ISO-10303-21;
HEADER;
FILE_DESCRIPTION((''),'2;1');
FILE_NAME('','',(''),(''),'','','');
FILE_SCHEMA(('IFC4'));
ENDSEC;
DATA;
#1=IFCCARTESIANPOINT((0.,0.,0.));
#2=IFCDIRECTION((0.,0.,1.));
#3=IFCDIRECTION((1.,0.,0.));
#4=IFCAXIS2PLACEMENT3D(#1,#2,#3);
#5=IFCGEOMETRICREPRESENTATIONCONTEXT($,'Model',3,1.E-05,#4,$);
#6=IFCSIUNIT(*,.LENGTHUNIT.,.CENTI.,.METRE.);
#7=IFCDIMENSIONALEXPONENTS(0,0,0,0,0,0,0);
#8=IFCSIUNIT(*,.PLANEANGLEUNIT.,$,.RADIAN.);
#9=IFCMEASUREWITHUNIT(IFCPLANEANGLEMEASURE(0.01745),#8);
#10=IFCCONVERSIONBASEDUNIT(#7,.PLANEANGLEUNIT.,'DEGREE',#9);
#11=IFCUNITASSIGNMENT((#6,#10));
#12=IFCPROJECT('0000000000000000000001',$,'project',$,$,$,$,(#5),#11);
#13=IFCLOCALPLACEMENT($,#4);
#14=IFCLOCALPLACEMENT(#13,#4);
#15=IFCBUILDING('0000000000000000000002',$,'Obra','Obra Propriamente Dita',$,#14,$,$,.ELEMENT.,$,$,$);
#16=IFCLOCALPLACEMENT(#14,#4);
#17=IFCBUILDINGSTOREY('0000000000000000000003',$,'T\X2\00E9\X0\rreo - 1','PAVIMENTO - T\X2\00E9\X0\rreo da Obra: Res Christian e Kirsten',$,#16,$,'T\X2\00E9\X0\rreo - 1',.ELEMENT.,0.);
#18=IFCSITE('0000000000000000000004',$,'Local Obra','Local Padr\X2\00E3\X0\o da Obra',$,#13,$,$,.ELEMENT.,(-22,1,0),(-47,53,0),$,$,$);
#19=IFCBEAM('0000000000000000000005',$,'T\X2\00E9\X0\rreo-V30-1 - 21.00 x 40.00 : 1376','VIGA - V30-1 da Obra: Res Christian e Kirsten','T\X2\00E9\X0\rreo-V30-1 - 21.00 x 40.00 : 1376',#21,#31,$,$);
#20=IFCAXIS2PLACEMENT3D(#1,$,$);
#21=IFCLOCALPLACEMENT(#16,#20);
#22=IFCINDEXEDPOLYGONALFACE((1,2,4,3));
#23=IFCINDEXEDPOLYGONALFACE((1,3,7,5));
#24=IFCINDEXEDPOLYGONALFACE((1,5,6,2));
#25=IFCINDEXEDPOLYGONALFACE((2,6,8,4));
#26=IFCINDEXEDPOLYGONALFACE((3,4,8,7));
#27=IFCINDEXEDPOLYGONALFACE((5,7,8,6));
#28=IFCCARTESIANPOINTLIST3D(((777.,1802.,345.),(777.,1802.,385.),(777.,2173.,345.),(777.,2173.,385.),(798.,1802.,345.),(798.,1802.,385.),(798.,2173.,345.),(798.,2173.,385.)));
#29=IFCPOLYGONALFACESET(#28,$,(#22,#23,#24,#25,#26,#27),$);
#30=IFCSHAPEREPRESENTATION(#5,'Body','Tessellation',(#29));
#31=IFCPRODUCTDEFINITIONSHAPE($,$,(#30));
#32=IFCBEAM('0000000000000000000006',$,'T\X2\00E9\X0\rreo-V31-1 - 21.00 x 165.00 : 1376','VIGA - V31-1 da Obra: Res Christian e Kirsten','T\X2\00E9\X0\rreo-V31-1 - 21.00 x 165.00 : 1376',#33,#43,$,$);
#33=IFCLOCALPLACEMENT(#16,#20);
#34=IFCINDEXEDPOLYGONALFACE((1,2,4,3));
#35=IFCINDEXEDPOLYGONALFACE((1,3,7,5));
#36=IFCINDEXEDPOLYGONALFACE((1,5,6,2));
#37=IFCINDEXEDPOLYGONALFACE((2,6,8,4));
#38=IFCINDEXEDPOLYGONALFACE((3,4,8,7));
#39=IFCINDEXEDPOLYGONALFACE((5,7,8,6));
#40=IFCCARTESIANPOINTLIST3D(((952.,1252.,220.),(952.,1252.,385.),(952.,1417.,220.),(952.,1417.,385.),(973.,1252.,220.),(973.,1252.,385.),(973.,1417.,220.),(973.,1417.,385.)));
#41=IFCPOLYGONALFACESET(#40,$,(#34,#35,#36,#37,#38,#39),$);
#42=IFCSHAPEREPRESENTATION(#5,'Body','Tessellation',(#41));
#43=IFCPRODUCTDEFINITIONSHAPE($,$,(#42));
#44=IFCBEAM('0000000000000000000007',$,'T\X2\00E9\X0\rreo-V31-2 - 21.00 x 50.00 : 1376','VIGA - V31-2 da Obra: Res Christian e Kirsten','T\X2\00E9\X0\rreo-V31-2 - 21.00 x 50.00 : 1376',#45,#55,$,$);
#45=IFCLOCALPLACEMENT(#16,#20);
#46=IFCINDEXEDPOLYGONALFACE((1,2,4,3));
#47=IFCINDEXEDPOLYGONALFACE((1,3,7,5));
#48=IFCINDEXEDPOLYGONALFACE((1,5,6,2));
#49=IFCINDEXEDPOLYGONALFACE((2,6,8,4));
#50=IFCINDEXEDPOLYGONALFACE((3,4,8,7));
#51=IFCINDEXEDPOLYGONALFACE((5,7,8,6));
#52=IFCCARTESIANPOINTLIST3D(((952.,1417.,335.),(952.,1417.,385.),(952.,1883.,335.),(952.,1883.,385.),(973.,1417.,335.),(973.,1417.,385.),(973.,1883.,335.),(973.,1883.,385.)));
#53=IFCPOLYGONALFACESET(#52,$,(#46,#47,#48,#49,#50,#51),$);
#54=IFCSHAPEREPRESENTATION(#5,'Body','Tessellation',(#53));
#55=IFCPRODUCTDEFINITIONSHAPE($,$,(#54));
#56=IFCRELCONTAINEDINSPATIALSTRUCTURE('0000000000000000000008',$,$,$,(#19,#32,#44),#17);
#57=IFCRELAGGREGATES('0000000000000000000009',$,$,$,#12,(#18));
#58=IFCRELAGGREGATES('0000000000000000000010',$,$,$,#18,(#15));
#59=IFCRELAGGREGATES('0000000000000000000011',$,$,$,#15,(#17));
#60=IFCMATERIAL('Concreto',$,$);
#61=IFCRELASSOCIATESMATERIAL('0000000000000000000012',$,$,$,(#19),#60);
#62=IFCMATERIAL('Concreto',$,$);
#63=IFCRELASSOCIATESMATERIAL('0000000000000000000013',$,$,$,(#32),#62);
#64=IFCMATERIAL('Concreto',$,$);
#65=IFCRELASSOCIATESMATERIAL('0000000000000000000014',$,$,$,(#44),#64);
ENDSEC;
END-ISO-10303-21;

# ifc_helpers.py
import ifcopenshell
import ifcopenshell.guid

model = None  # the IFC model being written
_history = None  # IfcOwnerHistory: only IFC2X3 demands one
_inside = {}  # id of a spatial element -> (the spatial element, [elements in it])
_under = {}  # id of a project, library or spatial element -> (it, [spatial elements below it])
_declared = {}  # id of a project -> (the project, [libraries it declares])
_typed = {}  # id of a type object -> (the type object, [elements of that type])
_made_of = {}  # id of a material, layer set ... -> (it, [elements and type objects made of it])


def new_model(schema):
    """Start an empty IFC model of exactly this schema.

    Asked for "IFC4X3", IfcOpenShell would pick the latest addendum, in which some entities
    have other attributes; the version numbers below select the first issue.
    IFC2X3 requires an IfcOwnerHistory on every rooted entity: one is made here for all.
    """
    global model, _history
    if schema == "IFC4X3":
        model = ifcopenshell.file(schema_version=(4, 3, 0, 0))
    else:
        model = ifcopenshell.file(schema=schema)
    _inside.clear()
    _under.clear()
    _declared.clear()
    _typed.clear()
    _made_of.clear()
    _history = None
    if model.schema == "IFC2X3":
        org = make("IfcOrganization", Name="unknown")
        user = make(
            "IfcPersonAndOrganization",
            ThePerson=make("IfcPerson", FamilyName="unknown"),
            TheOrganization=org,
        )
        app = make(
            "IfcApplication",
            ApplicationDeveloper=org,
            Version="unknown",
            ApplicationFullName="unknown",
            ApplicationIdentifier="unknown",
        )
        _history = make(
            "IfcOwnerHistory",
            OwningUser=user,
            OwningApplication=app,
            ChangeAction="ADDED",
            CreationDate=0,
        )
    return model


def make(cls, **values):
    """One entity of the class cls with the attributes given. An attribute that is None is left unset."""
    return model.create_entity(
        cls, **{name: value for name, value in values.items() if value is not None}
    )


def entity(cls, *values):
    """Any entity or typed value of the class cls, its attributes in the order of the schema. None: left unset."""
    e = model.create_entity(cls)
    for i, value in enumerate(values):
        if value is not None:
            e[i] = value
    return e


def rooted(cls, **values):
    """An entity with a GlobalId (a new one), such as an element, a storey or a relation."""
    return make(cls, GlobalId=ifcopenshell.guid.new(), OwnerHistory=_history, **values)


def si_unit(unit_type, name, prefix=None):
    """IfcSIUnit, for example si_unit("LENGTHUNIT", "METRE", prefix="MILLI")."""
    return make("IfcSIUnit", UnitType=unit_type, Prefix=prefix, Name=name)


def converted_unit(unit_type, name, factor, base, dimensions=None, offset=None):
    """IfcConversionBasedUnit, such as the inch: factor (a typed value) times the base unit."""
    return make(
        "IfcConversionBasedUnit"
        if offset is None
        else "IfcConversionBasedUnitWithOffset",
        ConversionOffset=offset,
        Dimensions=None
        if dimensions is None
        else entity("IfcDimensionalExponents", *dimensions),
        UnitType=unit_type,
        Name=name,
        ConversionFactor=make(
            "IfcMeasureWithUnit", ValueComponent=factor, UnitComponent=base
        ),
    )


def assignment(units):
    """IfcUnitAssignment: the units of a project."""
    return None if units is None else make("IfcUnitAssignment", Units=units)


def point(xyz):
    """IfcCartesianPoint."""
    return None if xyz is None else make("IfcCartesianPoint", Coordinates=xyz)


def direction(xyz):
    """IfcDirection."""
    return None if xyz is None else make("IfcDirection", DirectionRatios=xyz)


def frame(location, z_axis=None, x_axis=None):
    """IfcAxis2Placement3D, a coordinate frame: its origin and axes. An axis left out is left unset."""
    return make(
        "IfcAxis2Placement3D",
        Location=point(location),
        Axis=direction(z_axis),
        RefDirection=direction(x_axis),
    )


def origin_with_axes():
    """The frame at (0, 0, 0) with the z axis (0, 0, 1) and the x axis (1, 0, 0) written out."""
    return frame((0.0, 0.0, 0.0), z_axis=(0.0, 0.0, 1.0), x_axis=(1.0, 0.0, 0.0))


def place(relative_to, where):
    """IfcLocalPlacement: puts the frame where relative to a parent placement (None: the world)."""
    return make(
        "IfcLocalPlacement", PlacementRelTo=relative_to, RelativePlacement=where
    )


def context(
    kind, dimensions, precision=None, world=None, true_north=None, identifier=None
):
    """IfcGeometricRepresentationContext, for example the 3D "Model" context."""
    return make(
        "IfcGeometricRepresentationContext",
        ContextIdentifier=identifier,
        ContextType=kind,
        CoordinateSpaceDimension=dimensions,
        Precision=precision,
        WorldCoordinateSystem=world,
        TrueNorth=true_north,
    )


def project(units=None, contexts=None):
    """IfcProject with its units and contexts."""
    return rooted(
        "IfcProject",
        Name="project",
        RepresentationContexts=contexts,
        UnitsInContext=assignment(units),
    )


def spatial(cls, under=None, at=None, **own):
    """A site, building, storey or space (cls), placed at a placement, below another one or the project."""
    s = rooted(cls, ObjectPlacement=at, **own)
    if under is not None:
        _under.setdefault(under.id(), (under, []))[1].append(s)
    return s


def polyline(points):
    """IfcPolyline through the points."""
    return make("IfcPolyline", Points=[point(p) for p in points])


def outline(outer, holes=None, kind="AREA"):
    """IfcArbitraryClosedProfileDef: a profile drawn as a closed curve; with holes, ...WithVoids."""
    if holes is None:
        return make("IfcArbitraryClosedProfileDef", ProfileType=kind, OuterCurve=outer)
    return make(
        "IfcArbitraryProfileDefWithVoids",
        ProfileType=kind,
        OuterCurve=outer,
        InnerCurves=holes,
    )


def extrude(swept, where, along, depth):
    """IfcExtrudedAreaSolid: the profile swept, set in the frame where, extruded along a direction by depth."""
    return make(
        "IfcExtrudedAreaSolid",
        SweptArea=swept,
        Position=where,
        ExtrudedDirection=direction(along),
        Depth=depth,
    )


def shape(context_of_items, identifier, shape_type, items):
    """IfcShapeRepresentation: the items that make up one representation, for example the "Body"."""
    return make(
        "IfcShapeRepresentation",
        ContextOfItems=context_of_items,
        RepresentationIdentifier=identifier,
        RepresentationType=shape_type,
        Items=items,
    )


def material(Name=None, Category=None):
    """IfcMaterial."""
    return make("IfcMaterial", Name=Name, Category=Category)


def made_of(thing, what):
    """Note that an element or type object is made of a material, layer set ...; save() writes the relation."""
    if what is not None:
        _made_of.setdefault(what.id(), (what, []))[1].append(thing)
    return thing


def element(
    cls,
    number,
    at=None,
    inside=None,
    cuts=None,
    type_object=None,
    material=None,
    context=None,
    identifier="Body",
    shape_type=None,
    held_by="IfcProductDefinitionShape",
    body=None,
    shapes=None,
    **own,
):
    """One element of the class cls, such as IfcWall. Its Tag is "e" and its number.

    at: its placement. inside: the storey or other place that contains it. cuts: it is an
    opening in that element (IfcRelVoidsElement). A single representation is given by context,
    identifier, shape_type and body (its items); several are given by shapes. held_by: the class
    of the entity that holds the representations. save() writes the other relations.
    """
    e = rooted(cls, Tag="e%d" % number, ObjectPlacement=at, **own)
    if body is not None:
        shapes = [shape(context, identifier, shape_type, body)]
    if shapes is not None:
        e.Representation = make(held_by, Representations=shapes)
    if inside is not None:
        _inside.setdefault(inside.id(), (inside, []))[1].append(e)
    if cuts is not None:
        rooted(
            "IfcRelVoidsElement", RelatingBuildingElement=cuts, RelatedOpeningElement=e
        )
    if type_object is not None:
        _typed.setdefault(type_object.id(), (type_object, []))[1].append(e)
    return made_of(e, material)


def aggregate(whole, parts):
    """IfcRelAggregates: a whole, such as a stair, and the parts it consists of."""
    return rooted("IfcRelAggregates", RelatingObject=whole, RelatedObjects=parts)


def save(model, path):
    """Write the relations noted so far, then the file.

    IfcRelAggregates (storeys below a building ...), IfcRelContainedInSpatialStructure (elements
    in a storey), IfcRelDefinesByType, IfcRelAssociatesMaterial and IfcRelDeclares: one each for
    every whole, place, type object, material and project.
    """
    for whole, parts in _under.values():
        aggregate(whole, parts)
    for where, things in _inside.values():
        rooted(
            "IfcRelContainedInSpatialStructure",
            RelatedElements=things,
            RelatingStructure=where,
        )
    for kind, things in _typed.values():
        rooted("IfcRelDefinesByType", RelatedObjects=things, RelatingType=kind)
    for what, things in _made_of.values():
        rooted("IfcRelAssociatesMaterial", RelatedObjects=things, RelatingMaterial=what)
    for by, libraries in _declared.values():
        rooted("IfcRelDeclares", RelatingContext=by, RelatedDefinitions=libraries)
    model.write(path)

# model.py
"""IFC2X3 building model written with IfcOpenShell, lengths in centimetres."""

from ifc_helpers import new_model, entity, si_unit, converted_unit, frame, origin_with_axes, place, context, project, spatial, polyline, outline, extrude, material, element, save


model = new_model("IFC2X3")

# Units and contexts
model_context = context("Model", 3, precision=1e-05, world=origin_with_axes())
ifc_project = project(units=[si_unit("LENGTHUNIT", "METRE", prefix="CENTI"), converted_unit("PLANEANGLEUNIT", "DEGREE", entity("IfcPlaneAngleMeasure", 0.01745), si_unit("PLANEANGLEUNIT", "RADIAN"), dimensions=[0, 0, 0, 0, 0, 0, 0])], contexts=[model_context])

# Site, building, storey
site_placement = place(None, origin_with_axes())
site = spatial("IfcSite", under=ifc_project, at=site_placement, Name="Local Obra", Description="Local Padrão da Obra", CompositionType="ELEMENT", RefLatitude=(-22, 1, 0), RefLongitude=(-47, 53, 0))
building_placement = place(site_placement, origin_with_axes())
building = spatial("IfcBuilding", under=site, at=building_placement, Name="Obra", Description="Obra Propriamente Dita", CompositionType="ELEMENT")
storey_placement = place(building_placement, origin_with_axes())
storey = spatial("IfcBuildingStorey", under=building, at=storey_placement, Name="Térreo - 1", Description="PAVIMENTO - Térreo da Obra: Res Christian e Kirsten", LongName="Térreo - 1", CompositionType="ELEMENT", Elevation=0.0)

# Beams
ifc_material_1 = material(Name="Concreto")
beam_1_placement = place(storey_placement, frame((787.5, 1802.0, 385.0), z_axis=(0.0, 1.0, 0.0), x_axis=(1.0, 0.0, 0.0)))
element("IfcBeam", 1, at=beam_1_placement, inside=storey, material=ifc_material_1, Name="Térreo-V30-1 - 21.00 x 40.00 : 1376", Description="VIGA - V30-1 da Obra: Res Christian e Kirsten", ObjectType="Térreo-V30-1 - 21.00 x 40.00 : 1376", context=model_context, shape_type="SweptSolid", body=[
    extrude(outline(polyline([(-10.5, 0.0), (10.5, 0.0), (10.5, 40.0), (-10.5, 40.0), (-10.5, 0.0)])), origin_with_axes(), (0.0, 0.0, 1.0), 371.0),
])
ifc_material_2 = material(Name="Concreto")
beam_2_placement = place(storey_placement, frame((952.0, 1252.0, 385.0), z_axis=(0.0, 1.0, 0.0), x_axis=(1.0, 0.0, 0.0)))
element("IfcBeam", 2, at=beam_2_placement, inside=storey, material=ifc_material_2, Name="Térreo-V31-1 - 21.00 x 165.00 : 1376", Description="VIGA - V31-1 da Obra: Res Christian e Kirsten", ObjectType="Térreo-V31-1 - 21.00 x 165.00 : 1376", context=model_context, shape_type="SweptSolid", body=[
    extrude(outline(polyline([(0.0, 0.0), (21.0, 0.0), (21.0, 165.0), (0.0, 165.0), (0.0, 0.0)])), origin_with_axes(), (0.0, 0.0, 1.0), 165.0),
])
ifc_material_3 = material(Name="Concreto")
beam_3_placement = place(storey_placement, frame((952.0, 1417.0, 385.0), z_axis=(0.0, 1.0, 0.0), x_axis=(1.0, 0.0, 0.0)))
element("IfcBeam", 3, at=beam_3_placement, inside=storey, material=ifc_material_3, Name="Térreo-V31-2 - 21.00 x 50.00 : 1376", Description="VIGA - V31-2 da Obra: Res Christian e Kirsten", ObjectType="Térreo-V31-2 - 21.00 x 50.00 : 1376", context=model_context, shape_type="SweptSolid", body=[
    extrude(outline(polyline([(0.0, 0.0), (21.0, 0.0), (21.0, 50.0), (0.0, 50.0), (0.0, 0.0)])), origin_with_axes(), (0.0, 0.0, 1.0), 466.0),
])

save(model, "model.ifc")
